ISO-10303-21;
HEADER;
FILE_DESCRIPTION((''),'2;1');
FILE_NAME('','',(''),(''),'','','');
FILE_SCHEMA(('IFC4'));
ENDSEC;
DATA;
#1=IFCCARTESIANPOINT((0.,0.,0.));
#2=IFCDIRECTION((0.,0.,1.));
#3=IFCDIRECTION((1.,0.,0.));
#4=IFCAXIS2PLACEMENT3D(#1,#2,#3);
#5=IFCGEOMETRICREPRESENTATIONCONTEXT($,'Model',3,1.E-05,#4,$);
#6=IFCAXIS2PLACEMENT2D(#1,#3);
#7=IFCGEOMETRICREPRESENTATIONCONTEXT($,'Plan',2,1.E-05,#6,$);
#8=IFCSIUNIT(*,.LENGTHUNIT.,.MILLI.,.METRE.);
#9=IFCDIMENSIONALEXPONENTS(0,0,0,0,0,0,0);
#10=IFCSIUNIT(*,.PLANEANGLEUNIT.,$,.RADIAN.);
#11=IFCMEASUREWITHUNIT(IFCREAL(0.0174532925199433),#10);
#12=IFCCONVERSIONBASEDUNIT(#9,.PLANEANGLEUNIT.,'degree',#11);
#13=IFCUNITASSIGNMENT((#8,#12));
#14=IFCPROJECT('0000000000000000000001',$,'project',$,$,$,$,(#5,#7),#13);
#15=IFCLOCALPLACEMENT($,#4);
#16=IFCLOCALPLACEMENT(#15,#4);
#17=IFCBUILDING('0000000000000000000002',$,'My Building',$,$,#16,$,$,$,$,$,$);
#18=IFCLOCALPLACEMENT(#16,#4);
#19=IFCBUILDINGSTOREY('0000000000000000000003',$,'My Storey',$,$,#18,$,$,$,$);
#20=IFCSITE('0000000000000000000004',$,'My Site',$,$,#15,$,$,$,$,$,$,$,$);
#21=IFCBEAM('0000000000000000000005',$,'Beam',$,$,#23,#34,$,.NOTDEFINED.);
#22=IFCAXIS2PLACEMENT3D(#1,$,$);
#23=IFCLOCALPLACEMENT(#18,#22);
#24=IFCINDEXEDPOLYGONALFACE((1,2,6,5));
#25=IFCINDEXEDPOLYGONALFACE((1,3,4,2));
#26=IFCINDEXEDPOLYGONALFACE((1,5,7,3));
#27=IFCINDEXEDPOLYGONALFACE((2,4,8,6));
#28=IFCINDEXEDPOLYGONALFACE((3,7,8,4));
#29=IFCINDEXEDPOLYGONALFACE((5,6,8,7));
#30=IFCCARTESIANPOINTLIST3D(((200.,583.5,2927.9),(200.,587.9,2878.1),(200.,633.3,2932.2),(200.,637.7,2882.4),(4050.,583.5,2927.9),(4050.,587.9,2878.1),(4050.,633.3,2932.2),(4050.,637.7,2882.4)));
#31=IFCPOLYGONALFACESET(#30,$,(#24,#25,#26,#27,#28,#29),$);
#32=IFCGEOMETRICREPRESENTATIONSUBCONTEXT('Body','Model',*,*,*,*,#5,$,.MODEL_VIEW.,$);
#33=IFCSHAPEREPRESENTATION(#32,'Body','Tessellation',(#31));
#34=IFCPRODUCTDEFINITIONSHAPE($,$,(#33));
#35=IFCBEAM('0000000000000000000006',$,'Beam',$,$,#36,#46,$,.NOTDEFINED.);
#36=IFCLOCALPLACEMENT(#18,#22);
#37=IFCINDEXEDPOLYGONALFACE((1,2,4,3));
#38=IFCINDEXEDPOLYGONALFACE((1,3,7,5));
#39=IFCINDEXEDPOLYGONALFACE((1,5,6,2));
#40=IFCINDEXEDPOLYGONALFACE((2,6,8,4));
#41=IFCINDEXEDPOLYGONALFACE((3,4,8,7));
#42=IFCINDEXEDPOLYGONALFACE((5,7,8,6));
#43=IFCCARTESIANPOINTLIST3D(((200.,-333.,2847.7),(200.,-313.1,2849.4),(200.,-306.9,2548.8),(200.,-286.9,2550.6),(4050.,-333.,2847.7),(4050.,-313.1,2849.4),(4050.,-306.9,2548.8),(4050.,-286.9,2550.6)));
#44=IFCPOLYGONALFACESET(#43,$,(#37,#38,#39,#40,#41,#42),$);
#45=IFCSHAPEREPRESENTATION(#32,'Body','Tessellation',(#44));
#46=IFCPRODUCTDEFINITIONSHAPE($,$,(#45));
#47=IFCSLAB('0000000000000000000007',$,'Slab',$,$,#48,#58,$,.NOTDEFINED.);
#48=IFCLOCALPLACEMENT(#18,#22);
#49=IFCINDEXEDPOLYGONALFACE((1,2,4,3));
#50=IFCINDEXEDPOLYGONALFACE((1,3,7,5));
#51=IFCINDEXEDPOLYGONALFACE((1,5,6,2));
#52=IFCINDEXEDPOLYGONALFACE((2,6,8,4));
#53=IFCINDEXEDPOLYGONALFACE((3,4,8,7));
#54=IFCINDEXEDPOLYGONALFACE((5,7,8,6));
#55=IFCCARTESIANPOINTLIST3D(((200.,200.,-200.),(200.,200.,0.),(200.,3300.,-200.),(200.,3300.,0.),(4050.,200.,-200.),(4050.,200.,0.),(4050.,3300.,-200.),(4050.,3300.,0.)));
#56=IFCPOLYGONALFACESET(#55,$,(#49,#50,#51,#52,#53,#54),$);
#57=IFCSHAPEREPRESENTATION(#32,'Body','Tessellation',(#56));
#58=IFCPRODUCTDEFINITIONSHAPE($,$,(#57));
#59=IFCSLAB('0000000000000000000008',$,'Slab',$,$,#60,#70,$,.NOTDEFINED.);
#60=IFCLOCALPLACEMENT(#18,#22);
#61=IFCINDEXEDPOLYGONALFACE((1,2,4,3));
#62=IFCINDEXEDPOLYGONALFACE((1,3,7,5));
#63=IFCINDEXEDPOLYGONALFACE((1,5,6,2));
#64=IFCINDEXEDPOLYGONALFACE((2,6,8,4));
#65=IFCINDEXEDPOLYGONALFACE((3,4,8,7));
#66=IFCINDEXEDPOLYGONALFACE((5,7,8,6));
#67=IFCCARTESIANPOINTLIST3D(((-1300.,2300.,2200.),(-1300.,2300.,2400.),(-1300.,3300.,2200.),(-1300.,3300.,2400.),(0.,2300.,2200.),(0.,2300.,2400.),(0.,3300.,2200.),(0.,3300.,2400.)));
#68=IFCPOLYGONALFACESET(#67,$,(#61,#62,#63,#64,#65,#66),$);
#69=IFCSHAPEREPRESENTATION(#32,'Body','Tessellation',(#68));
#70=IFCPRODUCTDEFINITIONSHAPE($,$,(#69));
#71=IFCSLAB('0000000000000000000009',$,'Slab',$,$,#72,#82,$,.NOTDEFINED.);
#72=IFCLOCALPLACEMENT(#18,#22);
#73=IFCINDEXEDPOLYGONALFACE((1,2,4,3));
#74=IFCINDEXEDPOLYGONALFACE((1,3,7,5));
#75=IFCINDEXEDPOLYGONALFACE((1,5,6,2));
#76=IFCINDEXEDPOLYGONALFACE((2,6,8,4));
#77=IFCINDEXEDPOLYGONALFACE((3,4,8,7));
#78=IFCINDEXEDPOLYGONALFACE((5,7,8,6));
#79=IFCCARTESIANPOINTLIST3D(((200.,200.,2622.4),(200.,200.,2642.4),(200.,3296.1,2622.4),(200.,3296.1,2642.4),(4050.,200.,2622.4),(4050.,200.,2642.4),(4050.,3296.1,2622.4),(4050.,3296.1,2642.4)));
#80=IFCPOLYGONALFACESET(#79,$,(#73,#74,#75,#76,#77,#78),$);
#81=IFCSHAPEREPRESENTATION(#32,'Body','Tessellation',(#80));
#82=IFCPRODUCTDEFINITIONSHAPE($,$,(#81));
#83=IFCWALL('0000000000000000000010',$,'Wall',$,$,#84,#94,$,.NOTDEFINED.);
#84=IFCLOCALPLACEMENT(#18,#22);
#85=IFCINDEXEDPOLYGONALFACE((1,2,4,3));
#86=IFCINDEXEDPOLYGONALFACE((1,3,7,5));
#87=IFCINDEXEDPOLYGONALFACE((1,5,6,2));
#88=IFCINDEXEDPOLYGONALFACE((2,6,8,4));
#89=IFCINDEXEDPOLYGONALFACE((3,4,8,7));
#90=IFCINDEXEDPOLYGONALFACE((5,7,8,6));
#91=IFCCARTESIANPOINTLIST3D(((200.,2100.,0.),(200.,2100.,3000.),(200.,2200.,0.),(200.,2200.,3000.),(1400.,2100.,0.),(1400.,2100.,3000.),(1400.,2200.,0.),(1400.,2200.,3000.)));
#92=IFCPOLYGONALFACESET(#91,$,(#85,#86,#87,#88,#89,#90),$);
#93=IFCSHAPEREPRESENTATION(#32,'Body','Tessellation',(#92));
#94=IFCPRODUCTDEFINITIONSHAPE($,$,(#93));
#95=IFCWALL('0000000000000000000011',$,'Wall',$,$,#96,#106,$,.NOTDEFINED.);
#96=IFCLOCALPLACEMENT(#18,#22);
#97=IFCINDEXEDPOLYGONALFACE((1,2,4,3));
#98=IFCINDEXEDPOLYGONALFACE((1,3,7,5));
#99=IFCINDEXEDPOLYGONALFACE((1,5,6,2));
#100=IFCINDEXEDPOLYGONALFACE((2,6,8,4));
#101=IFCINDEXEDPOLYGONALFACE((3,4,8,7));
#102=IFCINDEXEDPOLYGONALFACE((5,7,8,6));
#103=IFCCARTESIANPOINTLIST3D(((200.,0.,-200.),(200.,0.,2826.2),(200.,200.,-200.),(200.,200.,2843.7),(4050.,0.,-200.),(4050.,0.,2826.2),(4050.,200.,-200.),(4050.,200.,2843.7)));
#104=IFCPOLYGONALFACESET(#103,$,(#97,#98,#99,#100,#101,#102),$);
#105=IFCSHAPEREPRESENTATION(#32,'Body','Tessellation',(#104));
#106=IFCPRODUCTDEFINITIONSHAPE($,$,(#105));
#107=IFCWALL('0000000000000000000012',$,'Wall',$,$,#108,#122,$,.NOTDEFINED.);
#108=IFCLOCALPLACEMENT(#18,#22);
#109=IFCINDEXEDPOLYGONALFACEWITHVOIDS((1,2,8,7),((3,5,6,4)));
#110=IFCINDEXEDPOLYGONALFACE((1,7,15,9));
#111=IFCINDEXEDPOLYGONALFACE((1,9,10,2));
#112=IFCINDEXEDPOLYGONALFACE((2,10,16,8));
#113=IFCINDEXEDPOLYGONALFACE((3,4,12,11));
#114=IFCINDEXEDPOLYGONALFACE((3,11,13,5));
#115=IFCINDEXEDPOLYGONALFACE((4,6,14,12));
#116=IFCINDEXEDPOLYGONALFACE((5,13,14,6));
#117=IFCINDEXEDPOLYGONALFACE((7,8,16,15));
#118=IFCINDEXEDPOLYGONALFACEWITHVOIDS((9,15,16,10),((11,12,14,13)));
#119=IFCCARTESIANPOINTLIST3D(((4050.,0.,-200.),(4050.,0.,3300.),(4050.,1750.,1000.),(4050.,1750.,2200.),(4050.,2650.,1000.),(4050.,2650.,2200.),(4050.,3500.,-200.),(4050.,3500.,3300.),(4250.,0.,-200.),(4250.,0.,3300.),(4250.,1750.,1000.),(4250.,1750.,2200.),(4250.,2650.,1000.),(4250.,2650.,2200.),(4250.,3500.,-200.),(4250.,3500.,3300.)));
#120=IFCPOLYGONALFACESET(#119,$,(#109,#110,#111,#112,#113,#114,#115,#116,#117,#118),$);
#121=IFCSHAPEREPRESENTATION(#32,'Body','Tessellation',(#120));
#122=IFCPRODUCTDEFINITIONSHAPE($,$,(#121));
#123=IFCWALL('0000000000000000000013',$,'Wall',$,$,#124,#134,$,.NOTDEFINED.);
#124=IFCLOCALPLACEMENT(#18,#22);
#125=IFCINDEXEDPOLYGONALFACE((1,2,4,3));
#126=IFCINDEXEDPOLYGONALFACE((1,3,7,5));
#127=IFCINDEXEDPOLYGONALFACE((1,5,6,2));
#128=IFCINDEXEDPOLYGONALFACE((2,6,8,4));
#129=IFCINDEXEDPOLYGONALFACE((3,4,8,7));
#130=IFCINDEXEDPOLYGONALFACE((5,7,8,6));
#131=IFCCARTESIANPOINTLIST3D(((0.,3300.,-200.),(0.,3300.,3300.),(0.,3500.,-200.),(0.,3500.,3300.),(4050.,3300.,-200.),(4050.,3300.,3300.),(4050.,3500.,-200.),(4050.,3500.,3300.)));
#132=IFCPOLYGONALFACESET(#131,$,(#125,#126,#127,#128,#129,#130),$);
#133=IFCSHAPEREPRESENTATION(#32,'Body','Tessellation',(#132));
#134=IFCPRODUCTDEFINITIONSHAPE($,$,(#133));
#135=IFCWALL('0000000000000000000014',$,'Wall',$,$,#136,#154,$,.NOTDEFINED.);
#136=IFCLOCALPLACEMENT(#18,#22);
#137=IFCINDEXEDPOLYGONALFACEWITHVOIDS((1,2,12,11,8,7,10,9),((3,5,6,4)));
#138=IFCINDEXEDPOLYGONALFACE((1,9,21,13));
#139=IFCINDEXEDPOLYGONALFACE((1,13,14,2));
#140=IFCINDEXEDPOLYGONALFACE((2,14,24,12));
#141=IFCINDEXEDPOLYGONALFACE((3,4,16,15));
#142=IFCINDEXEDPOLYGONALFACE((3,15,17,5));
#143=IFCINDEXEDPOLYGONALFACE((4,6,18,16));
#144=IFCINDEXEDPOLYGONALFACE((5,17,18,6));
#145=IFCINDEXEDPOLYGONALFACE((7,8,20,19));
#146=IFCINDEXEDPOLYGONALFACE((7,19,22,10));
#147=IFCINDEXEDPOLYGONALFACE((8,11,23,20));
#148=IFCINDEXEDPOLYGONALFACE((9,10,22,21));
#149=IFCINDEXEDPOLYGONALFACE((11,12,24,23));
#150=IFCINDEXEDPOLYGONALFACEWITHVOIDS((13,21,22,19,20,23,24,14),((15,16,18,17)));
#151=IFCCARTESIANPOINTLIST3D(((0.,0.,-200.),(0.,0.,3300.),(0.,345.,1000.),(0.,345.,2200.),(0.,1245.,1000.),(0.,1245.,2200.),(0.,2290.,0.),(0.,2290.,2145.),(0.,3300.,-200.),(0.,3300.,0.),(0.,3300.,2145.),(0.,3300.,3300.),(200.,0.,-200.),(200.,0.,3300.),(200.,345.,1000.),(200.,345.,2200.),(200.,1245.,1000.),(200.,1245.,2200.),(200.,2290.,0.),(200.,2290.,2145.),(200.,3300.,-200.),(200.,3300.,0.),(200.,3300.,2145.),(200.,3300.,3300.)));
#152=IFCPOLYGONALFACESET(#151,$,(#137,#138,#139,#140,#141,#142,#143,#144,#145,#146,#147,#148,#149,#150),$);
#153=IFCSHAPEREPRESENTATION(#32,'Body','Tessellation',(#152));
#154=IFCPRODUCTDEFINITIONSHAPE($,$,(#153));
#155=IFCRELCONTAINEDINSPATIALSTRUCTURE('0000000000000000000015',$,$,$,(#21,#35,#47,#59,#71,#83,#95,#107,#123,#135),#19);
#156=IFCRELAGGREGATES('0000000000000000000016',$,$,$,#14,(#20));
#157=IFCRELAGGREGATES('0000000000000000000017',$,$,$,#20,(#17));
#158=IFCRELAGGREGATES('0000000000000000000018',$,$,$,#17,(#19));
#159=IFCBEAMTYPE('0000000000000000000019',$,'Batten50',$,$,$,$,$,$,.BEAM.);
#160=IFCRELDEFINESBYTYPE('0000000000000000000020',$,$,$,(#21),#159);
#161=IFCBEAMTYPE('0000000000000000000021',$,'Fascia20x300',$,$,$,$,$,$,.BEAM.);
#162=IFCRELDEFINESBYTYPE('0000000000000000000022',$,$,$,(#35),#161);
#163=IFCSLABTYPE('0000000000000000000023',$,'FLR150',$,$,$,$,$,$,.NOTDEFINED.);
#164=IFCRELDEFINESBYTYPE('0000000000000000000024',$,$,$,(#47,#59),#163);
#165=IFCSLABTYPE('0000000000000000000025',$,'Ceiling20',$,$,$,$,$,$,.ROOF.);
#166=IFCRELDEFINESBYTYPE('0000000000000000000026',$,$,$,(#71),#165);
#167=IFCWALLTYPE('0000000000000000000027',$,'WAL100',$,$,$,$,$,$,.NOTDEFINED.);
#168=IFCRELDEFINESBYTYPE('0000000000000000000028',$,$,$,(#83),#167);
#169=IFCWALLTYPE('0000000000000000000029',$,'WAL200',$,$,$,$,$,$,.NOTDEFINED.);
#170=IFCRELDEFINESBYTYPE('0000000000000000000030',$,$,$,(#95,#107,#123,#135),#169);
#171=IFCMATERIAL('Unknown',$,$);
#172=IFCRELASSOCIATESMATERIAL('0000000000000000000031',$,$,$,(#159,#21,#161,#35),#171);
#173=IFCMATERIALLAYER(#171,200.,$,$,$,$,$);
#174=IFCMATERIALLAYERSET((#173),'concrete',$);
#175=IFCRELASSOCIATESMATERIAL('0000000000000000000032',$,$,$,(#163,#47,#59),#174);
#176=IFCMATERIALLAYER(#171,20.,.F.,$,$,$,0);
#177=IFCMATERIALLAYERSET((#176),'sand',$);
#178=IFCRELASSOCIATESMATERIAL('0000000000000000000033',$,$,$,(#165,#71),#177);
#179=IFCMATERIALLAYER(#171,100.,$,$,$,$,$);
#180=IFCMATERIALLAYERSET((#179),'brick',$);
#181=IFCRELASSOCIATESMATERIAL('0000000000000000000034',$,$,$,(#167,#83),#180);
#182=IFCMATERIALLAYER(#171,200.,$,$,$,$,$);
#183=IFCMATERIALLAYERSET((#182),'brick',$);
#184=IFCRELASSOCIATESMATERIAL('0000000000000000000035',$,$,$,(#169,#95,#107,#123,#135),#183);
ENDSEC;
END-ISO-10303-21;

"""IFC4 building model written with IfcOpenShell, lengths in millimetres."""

from ifc_helpers import new_model, entity, si_unit, converted_unit, frame, frame_2d, origin_with_axes, place, context, subcontext, project, spatial, line, indexed_curve, rectangle, outline, extrude, clip, halfspace, source, transform, mapped, material, layer, layer_set, layer_usage, material_profile, profile_set, profile_usage, type_object, element, save


model = new_model("IFC4")

# Units and contexts
model_context = context("Model", 3, precision=1e-05, world=origin_with_axes())
plan_context = context("Plan", 2, precision=1e-05, world=frame_2d((0.0, 0.0, 0.0), x_axis=(1.0, 0.0, 0.0)))
body_context = subcontext(model_context, "Body", "Model", "MODEL_VIEW")
ifc_project = project(units=[si_unit("LENGTHUNIT", "METRE", prefix="MILLI"), converted_unit("PLANEANGLEUNIT", "degree", entity("IfcReal", 0.0174532925199433), si_unit("PLANEANGLEUNIT", "RADIAN"), dimensions=[0, 0, 0, 0, 0, 0, 0])], contexts=[model_context, plan_context])

# Site, building, storey
site_placement = place(None, origin_with_axes())
site = spatial("IfcSite", under=ifc_project, at=site_placement, Name="My Site")
building_placement = place(site_placement, origin_with_axes())
building = spatial("IfcBuilding", under=site, at=building_placement, Name="My Building")
storey_placement = place(building_placement, origin_with_axes())
storey = spatial("IfcBuildingStorey", under=building, at=storey_placement, Name="My Storey")

# Shared definitions
ifc_material = material(Name="Unknown")

# Beams
ifc_material_profile_1 = material_profile(ifc_material, rectangle(XDim=50.0, YDim=50.0))
ifc_profile_set_1 = profile_set([ifc_material_profile_1], Name="blank")
beam_type_1 = type_object("IfcBeamType", Name="Batten50", PredefinedType="BEAM", material=ifc_profile_set_1)
ifc_profile_usage_1 = profile_usage(ifc_profile_set_1, cardinal=5)
beam_1_placement = place(storey_placement, frame((200.0, 610.6, 2905.1), z_axis=(1.0, 0.0, 0.0), x_axis=(0.0, 0.996195, 0.087156)))
element("IfcBeam", 1, at=beam_1_placement, inside=storey, type_object=beam_type_1, material=ifc_profile_usage_1, Name="Beam", PredefinedType="NOTDEFINED", context=body_context, shape_type="SweptSolid", body=[
    extrude(rectangle(XDim=50.0, YDim=50.0), origin_with_axes(), (0.0, 0.0, 1.0), 3850.0),
])
ifc_material_profile_2 = material_profile(ifc_material, rectangle(XDim=20.0, YDim=300.0))
ifc_profile_set_2 = profile_set([ifc_material_profile_2], Name="sand")
ifc_profile_usage_2 = profile_usage(ifc_profile_set_2, cardinal=5)
beam_type_2 = type_object("IfcBeamType", Name="Fascia20x300", PredefinedType="BEAM", material=ifc_profile_set_2)
beam_2_placement = place(storey_placement, frame((200.0, -310.0, 2699.1), z_axis=(1.0, 0.0, 0.0), x_axis=(0.0, 0.996195, 0.087156)))
element("IfcBeam", 2, at=beam_2_placement, inside=storey, type_object=beam_type_2, material=ifc_profile_usage_2, Name="Beam", PredefinedType="NOTDEFINED", context=body_context, shape_type="SweptSolid", body=[
    extrude(rectangle(XDim=20.0, YDim=300.0), origin_with_axes(), (0.0, 0.0, 1.0), 3850.0),
])

# Slabs
ifc_layer_1 = layer(ifc_material, 200.0)
ifc_layer_set_1 = layer_set([ifc_layer_1], Name="concrete")
ifc_layer_usage_1 = layer_usage(ifc_layer_set_1, "AXIS3", "POSITIVE", 0.0)
slab_type_1 = type_object("IfcSlabType", Name="FLR150", PredefinedType="NOTDEFINED", material=ifc_layer_set_1)
slab_1_placement = place(storey_placement, frame((200.0, 200.0, -200.0), z_axis=(0.0, 0.0, 1.0), x_axis=(1.0, 0.0, 0.0)))
element("IfcSlab", 3, at=slab_1_placement, inside=storey, type_object=slab_type_1, material=ifc_layer_usage_1, Name="Slab", PredefinedType="NOTDEFINED", context=body_context, shape_type="SweptSolid", body=[
    extrude(outline(indexed_curve([(0.0, 0.0), (3850.0, 0.0), (3850.0, 3100.0), (0.0, 3100.0)], segments=[line(3, 2), line(2, 1), line(1, 4), line(4, 3)], self_intersect=False)), None, (0.0, 0.0, 1.0), 200.0),
])
ifc_layer_usage_2 = layer_usage(ifc_layer_set_1, "AXIS3", "POSITIVE", 0.0)
slab_2_placement = place(storey_placement, frame((-1300.0, 2300.0, 2200.0), z_axis=(0.0, 0.0, 1.0), x_axis=(1.0, 0.0, 0.0)))
element("IfcSlab", 4, at=slab_2_placement, inside=storey, type_object=slab_type_1, material=ifc_layer_usage_2, Name="Slab", PredefinedType="NOTDEFINED", context=body_context, shape_type="SweptSolid", body=[
    extrude(outline(indexed_curve([(0.0, 0.0), (1300.0, 0.0), (1300.0, 1000.0), (0.0, 1000.0)], segments=[line(3, 2), line(2, 1), line(1, 4), line(4, 3)], self_intersect=False)), None, (0.0, 0.0, 1.0), 200.0),
])
ifc_layer_2 = layer(ifc_material, 20.0, ventilated=False, Priority=0)
ifc_layer_set_2 = layer_set([ifc_layer_2], Name="sand")
ifc_layer_usage_3 = layer_usage(ifc_layer_set_2, "AXIS3", "POSITIVE", 0.0)
slab_type_2 = type_object("IfcSlabType", Name="Ceiling20", PredefinedType="ROOF", material=ifc_layer_set_2)
slab_3_placement = place(storey_placement, frame((200.0, 200.0, 2622.4), z_axis=(0.0, 0.0, 1.0), x_axis=(1.0, 0.0, 0.0)))
element("IfcSlab", 5, at=slab_3_placement, inside=storey, type_object=slab_type_2, material=ifc_layer_usage_3, Name="Slab", PredefinedType="NOTDEFINED", context=body_context, shape_type="SweptSolid", body=[
    extrude(outline(indexed_curve([(0.0, 0.0), (3850.0, 0.0), (3850.0, 3096.1), (0.0, 3096.1)], segments=[line(3, 2), line(2, 1), line(1, 4), line(4, 3)], self_intersect=False)), None, (0.0, 0.0, 1.0), 20.0),
])

# Walls
ifc_layer_3 = layer(ifc_material, 100.0)
ifc_layer_set_3 = layer_set([ifc_layer_3], Name="brick")
ifc_layer_usage_4 = layer_usage(ifc_layer_set_3, "AXIS2", "POSITIVE", 0.0)
wall_type_1 = type_object("IfcWallType", Name="WAL100", PredefinedType="NOTDEFINED", material=ifc_layer_set_3)
wall_1_placement = place(storey_placement, frame((200.0, 2100.0, 0.0), z_axis=(0.0, 0.0, 1.0), x_axis=(1.0, 0.0, 0.0)))
element("IfcWall", 6, at=wall_1_placement, inside=storey, type_object=wall_type_1, material=ifc_layer_usage_4, Name="Wall", PredefinedType="NOTDEFINED", context=body_context, shape_type="SweptSolid", body=[
    extrude(outline(indexed_curve([(0.0, 0.0), (0.0, 100.0), (1200.0, 100.0), (1200.0, 0.0), (0.0, 0.0)], self_intersect=False)), origin_with_axes(), (0.0, 0.0, 1.0), 3000.0),
])
ifc_layer_4 = layer(ifc_material, 200.0)
ifc_layer_set_4 = layer_set([ifc_layer_4], Name="brick")
ifc_layer_usage_5 = layer_usage(ifc_layer_set_4, "AXIS2", "POSITIVE", 0.0)
wall_type_2 = type_object("IfcWallType", Name="WAL200", PredefinedType="NOTDEFINED", material=ifc_layer_set_4)
wall_2_placement = place(storey_placement, frame((200.0, 0.0, -200.0), z_axis=(0.0, 0.0, 1.0), x_axis=(1.0, 0.0, 0.0)))
element("IfcWall", 7, at=wall_2_placement, inside=storey, type_object=wall_type_2, material=ifc_layer_usage_5, Name="Wall", PredefinedType="NOTDEFINED", context=body_context, shape_type="Clipping", body=[
    clip(extrude(outline(indexed_curve([(0.0, 0.0), (0.0, 200.0), (3850.0, 200.0), (3850.0, 0.0), (0.0, 0.0)], self_intersect=False)), origin_with_axes(), (0.0, 0.0, 1.0), 3043.7), halfspace(frame((0.0, 200.0, 3043.7), z_axis=(0.0, -0.087156, 0.996195), x_axis=(1.0, 0.0, 0.0)), False)),
])

# Wall, opening
ifc_layer_usage_6 = layer_usage(ifc_layer_set_4, "AXIS2", "POSITIVE", 0.0)
wall_3_placement = place(storey_placement, frame((4250.0, 0.0, -200.0), z_axis=(0.0, 0.0, 1.0), x_axis=(0.0, 1.0, 0.0)))
wall_3 = element("IfcWall", 8, at=wall_3_placement, inside=storey, type_object=wall_type_2, material=ifc_layer_usage_6, Name="Wall", PredefinedType="NOTDEFINED", context=body_context, shape_type="SweptSolid", body=[
    extrude(outline(indexed_curve([(0.0, 0.0), (0.0, 200.0), (3500.0, 200.0), (3500.0, 0.0), (0.0, 0.0)], self_intersect=False)), origin_with_axes(), (0.0, 0.0, 1.0), 3500.0),
])
shared_shape_1 = source(origin_with_axes(), body_context, "Body", "SweptSolid", [
    extrude(outline(indexed_curve([(0.0, 0.0, 0.0), (900.0, 0.0, 0.0), (900.0, 0.0, 1200.0), (0.0, 0.0, 1200.0)], segments=[line(1, 2), line(2, 3), line(3, 4), line(4, 1)])), frame((0.0, -100.0, 0.0), z_axis=(0.0, 0.0, 1.0), x_axis=(1.0, 0.0, 0.0)), (0.0, 1.0, 0.0), 400.0),
])
opening_1_placement = place(wall_3_placement, frame((1750.0, 0.0, 1200.0), z_axis=(0.0, 0.0, 1.0), x_axis=(1.0, 0.0, 0.0)))
element("IfcOpeningElement", 9, at=opening_1_placement, cuts=wall_3, PredefinedType="NOTDEFINED", context=body_context, shape_type="MappedRepresentation", body=[
    mapped(shared_shape_1, transform((0.0, 0.0, 0.0), x_axis=(1.0, 0.0, 0.0), y_axis=(0.0, 1.0, 0.0), z_axis=(0.0, 0.0, 1.0), scale=1.0)),
])

# Wall
ifc_layer_usage_7 = layer_usage(ifc_layer_set_4, "AXIS2", "POSITIVE", 0.0)
wall_4_placement = place(storey_placement, frame((4050.0, 3500.0, -200.0), z_axis=(0.0, 0.0, 1.0), x_axis=(-1.0, 0.0, 0.0)))
element("IfcWall", 10, at=wall_4_placement, inside=storey, type_object=wall_type_2, material=ifc_layer_usage_7, Name="Wall", PredefinedType="NOTDEFINED", context=body_context, shape_type="SweptSolid", body=[
    extrude(outline(indexed_curve([(0.0, 0.0), (0.0, 200.0), (4050.0, 200.0), (4050.0, 0.0), (0.0, 0.0)], self_intersect=False)), origin_with_axes(), (0.0, 0.0, 1.0), 3500.0),
])

# Wall, openings
ifc_layer_usage_8 = layer_usage(ifc_layer_set_4, "AXIS2", "POSITIVE", 0.0)
wall_5_placement = place(storey_placement, frame((0.0, 3300.0, -200.0), z_axis=(0.0, 0.0, 1.0), x_axis=(0.0, -1.0, 0.0)))
wall_5 = element("IfcWall", 11, at=wall_5_placement, inside=storey, type_object=wall_type_2, material=ifc_layer_usage_8, Name="Wall", PredefinedType="NOTDEFINED", context=body_context, shape_type="SweptSolid", body=[
    extrude(outline(indexed_curve([(0.0, 0.0), (0.0, 200.0), (3300.0, 200.0), (3300.0, 0.0), (0.0, 0.0)], self_intersect=False)), origin_with_axes(), (0.0, 0.0, 1.0), 3500.0),
])
shared_shape_2 = source(origin_with_axes(), body_context, "Body", "SweptSolid", [
    extrude(outline(indexed_curve([(0.0, 0.0, 0.0), (1010.0, 0.0, 0.0), (1010.0, 0.0, 2145.0), (0.0, 0.0, 2145.0)], segments=[line(1, 2), line(2, 3), line(3, 4), line(4, 1)])), frame((0.0, -100.0, 0.0), z_axis=(0.0, 0.0, 1.0), x_axis=(1.0, 0.0, 0.0)), (0.0, 1.0, 0.0), 400.0),
])
opening_2_placement = place(wall_5_placement, frame((0.0, 0.0, 200.0), z_axis=(0.0, 0.0, 1.0), x_axis=(1.0, 0.0, 0.0)))
element("IfcOpeningElement", 12, at=opening_2_placement, cuts=wall_5, PredefinedType="NOTDEFINED", context=body_context, shape_type="MappedRepresentation", body=[
    mapped(shared_shape_2, transform((0.0, 0.0, 0.0), x_axis=(1.0, 0.0, 0.0), y_axis=(0.0, 1.0, 0.0), z_axis=(0.0, 0.0, 1.0), scale=1.0)),
])
opening_3_placement = place(wall_5_placement, frame((2055.0, 0.0, 1200.0), z_axis=(0.0, 0.0, 1.0), x_axis=(1.0, 0.0, 0.0)))
element("IfcOpeningElement", 13, at=opening_3_placement, cuts=wall_5, PredefinedType="NOTDEFINED", context=body_context, shape_type="MappedRepresentation", body=[
    mapped(shared_shape_1, transform((0.0, 0.0, 0.0), x_axis=(1.0, 0.0, 0.0), y_axis=(0.0, 1.0, 0.0), z_axis=(0.0, 0.0, 1.0), scale=1.0)),
])

save(model, "model.ifc")
